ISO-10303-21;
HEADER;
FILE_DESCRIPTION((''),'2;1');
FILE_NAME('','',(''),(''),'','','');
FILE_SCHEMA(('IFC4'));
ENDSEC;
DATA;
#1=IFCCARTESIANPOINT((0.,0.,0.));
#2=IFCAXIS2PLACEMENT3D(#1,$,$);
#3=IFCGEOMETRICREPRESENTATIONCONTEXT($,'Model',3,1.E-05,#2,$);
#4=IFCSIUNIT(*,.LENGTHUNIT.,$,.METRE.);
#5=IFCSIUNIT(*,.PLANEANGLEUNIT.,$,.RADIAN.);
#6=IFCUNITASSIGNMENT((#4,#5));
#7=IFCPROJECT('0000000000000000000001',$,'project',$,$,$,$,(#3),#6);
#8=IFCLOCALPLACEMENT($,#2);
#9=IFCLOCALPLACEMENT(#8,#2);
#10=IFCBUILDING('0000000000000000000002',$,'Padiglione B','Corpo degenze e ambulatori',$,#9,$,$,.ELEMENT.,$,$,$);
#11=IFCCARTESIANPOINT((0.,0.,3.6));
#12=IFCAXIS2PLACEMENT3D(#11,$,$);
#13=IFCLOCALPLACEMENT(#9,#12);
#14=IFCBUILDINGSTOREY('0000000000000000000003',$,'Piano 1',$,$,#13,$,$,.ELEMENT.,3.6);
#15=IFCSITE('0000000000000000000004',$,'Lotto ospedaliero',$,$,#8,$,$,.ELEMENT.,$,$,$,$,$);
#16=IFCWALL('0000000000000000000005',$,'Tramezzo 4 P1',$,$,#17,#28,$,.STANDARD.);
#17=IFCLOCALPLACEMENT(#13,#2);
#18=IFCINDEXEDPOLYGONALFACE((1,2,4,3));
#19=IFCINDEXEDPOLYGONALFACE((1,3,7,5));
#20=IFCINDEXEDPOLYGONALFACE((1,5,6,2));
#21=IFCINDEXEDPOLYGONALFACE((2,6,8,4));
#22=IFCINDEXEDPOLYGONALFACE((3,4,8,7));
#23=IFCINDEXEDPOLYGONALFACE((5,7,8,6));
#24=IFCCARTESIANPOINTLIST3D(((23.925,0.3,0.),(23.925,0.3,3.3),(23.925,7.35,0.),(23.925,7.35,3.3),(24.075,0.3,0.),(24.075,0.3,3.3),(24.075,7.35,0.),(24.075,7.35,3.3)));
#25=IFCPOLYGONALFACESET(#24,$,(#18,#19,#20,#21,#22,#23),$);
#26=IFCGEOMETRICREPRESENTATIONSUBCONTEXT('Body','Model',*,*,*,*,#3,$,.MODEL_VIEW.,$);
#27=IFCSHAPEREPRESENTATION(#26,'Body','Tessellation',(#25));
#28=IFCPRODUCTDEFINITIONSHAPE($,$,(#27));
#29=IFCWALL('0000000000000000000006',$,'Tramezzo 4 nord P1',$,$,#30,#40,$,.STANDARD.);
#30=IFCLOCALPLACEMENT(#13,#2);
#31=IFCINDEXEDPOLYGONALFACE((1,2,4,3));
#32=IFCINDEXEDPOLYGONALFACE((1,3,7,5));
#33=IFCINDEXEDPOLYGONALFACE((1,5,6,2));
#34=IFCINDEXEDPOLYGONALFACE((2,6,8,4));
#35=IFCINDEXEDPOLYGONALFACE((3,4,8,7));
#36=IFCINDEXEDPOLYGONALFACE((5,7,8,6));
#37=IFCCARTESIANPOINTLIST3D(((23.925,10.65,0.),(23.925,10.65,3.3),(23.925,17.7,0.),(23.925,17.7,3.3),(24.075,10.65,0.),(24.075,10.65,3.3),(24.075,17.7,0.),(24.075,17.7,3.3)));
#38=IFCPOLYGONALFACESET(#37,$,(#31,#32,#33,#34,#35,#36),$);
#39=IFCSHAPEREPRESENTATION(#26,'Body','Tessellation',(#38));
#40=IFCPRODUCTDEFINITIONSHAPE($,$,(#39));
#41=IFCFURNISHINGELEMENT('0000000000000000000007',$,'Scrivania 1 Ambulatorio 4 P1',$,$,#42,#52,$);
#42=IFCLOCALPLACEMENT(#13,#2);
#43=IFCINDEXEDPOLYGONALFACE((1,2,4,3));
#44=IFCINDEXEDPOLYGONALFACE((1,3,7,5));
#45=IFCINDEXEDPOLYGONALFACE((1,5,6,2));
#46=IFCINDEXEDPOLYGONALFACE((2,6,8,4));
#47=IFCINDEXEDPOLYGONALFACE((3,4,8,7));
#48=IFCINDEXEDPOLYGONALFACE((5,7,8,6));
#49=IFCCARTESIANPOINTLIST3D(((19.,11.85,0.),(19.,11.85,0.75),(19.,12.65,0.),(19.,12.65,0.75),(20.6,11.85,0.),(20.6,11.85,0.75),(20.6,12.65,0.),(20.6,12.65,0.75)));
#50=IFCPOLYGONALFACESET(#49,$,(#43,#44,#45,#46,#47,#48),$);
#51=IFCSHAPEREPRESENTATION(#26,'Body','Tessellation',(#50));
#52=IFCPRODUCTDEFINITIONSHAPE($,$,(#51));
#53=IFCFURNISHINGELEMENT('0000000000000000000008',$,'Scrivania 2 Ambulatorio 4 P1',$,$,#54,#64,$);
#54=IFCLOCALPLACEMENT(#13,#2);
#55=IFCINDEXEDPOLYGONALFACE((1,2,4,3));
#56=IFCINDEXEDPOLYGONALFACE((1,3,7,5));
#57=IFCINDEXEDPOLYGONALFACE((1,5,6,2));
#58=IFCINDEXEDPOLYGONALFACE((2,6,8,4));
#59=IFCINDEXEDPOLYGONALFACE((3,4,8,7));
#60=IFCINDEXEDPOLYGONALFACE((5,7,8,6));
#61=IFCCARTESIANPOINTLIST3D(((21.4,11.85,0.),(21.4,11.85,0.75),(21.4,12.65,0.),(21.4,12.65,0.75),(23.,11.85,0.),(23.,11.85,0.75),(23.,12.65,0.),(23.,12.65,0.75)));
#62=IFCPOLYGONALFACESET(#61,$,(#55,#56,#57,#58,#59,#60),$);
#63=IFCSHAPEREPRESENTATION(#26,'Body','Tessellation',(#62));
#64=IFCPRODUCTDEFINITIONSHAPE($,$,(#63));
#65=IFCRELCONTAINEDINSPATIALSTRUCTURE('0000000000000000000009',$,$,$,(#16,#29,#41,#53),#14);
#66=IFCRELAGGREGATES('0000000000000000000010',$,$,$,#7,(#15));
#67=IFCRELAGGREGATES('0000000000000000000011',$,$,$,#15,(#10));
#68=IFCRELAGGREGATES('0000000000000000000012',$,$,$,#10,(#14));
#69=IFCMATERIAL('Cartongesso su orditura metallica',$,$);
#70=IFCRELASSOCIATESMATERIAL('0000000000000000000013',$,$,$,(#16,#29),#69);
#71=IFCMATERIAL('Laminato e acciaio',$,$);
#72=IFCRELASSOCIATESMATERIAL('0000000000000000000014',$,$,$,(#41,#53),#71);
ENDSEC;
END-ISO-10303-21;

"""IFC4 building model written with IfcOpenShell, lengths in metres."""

from ifc_helpers import new_model, si_unit, frame, frame_2d, origin, place, context, subcontext, project, spatial, rectangle, extrude, material, element, save


model = new_model("IFC4")

# Units and contexts
model_context = context("Model", 3, precision=1e-05, world=origin())
body_context = subcontext(model_context, "Body", "Model", "MODEL_VIEW")
ifc_project = project(units=[si_unit("LENGTHUNIT", "METRE"), si_unit("PLANEANGLEUNIT", "RADIAN")], contexts=[model_context])

# Site, building, storey
site_placement = place(None, origin())
site = spatial("IfcSite", under=ifc_project, at=site_placement, Name="Lotto ospedaliero", CompositionType="ELEMENT")
building_placement = place(site_placement, origin())
building = spatial("IfcBuilding", under=site, at=building_placement, Name="Padiglione B", Description="Corpo degenze e ambulatori", CompositionType="ELEMENT")
storey_placement = place(building_placement, frame((0.0, 0.0, 3.6)))
storey = spatial("IfcBuildingStorey", under=building, at=storey_placement, Name="Piano 1", CompositionType="ELEMENT", Elevation=3.6)

# Walls
ifc_material_1 = material(Name="Cartongesso su orditura metallica")
for number, where, name in (
    (1, (23.925, 0.3, 0.0), "Tramezzo 4 P1"),
    (2, (23.925, 10.65, 0.0), "Tramezzo 4 nord P1"),
):
    element("IfcWall", number, at=place(storey_placement, frame(where)), inside=storey, material=ifc_material_1, Name=name, PredefinedType="STANDARD", context=body_context, shape_type="SweptSolid", body=[
        extrude(rectangle(XDim=0.15, YDim=7.05, at=frame_2d((0.075, 3.525))), origin(), (0.0, 0.0, 1.0), 3.3),
    ])

# Furnishing elements
ifc_material_2 = material(Name="Laminato e acciaio")
for number, where, name in (
    (3, (19.0, 11.85, 0.0), "Scrivania 1 Ambulatorio 4 P1"),
    (4, (21.4, 11.85, 0.0), "Scrivania 2 Ambulatorio 4 P1"),
):
    element("IfcFurnishingElement", number, at=place(storey_placement, frame(where)), inside=storey, material=ifc_material_2, Name=name, context=body_context, shape_type="SweptSolid", body=[
        extrude(rectangle(XDim=1.6, YDim=0.8, at=frame_2d((0.8, 0.4))), origin(), (0.0, 0.0, 1.0), 0.75),
    ])

save(model, "model.ifc")
